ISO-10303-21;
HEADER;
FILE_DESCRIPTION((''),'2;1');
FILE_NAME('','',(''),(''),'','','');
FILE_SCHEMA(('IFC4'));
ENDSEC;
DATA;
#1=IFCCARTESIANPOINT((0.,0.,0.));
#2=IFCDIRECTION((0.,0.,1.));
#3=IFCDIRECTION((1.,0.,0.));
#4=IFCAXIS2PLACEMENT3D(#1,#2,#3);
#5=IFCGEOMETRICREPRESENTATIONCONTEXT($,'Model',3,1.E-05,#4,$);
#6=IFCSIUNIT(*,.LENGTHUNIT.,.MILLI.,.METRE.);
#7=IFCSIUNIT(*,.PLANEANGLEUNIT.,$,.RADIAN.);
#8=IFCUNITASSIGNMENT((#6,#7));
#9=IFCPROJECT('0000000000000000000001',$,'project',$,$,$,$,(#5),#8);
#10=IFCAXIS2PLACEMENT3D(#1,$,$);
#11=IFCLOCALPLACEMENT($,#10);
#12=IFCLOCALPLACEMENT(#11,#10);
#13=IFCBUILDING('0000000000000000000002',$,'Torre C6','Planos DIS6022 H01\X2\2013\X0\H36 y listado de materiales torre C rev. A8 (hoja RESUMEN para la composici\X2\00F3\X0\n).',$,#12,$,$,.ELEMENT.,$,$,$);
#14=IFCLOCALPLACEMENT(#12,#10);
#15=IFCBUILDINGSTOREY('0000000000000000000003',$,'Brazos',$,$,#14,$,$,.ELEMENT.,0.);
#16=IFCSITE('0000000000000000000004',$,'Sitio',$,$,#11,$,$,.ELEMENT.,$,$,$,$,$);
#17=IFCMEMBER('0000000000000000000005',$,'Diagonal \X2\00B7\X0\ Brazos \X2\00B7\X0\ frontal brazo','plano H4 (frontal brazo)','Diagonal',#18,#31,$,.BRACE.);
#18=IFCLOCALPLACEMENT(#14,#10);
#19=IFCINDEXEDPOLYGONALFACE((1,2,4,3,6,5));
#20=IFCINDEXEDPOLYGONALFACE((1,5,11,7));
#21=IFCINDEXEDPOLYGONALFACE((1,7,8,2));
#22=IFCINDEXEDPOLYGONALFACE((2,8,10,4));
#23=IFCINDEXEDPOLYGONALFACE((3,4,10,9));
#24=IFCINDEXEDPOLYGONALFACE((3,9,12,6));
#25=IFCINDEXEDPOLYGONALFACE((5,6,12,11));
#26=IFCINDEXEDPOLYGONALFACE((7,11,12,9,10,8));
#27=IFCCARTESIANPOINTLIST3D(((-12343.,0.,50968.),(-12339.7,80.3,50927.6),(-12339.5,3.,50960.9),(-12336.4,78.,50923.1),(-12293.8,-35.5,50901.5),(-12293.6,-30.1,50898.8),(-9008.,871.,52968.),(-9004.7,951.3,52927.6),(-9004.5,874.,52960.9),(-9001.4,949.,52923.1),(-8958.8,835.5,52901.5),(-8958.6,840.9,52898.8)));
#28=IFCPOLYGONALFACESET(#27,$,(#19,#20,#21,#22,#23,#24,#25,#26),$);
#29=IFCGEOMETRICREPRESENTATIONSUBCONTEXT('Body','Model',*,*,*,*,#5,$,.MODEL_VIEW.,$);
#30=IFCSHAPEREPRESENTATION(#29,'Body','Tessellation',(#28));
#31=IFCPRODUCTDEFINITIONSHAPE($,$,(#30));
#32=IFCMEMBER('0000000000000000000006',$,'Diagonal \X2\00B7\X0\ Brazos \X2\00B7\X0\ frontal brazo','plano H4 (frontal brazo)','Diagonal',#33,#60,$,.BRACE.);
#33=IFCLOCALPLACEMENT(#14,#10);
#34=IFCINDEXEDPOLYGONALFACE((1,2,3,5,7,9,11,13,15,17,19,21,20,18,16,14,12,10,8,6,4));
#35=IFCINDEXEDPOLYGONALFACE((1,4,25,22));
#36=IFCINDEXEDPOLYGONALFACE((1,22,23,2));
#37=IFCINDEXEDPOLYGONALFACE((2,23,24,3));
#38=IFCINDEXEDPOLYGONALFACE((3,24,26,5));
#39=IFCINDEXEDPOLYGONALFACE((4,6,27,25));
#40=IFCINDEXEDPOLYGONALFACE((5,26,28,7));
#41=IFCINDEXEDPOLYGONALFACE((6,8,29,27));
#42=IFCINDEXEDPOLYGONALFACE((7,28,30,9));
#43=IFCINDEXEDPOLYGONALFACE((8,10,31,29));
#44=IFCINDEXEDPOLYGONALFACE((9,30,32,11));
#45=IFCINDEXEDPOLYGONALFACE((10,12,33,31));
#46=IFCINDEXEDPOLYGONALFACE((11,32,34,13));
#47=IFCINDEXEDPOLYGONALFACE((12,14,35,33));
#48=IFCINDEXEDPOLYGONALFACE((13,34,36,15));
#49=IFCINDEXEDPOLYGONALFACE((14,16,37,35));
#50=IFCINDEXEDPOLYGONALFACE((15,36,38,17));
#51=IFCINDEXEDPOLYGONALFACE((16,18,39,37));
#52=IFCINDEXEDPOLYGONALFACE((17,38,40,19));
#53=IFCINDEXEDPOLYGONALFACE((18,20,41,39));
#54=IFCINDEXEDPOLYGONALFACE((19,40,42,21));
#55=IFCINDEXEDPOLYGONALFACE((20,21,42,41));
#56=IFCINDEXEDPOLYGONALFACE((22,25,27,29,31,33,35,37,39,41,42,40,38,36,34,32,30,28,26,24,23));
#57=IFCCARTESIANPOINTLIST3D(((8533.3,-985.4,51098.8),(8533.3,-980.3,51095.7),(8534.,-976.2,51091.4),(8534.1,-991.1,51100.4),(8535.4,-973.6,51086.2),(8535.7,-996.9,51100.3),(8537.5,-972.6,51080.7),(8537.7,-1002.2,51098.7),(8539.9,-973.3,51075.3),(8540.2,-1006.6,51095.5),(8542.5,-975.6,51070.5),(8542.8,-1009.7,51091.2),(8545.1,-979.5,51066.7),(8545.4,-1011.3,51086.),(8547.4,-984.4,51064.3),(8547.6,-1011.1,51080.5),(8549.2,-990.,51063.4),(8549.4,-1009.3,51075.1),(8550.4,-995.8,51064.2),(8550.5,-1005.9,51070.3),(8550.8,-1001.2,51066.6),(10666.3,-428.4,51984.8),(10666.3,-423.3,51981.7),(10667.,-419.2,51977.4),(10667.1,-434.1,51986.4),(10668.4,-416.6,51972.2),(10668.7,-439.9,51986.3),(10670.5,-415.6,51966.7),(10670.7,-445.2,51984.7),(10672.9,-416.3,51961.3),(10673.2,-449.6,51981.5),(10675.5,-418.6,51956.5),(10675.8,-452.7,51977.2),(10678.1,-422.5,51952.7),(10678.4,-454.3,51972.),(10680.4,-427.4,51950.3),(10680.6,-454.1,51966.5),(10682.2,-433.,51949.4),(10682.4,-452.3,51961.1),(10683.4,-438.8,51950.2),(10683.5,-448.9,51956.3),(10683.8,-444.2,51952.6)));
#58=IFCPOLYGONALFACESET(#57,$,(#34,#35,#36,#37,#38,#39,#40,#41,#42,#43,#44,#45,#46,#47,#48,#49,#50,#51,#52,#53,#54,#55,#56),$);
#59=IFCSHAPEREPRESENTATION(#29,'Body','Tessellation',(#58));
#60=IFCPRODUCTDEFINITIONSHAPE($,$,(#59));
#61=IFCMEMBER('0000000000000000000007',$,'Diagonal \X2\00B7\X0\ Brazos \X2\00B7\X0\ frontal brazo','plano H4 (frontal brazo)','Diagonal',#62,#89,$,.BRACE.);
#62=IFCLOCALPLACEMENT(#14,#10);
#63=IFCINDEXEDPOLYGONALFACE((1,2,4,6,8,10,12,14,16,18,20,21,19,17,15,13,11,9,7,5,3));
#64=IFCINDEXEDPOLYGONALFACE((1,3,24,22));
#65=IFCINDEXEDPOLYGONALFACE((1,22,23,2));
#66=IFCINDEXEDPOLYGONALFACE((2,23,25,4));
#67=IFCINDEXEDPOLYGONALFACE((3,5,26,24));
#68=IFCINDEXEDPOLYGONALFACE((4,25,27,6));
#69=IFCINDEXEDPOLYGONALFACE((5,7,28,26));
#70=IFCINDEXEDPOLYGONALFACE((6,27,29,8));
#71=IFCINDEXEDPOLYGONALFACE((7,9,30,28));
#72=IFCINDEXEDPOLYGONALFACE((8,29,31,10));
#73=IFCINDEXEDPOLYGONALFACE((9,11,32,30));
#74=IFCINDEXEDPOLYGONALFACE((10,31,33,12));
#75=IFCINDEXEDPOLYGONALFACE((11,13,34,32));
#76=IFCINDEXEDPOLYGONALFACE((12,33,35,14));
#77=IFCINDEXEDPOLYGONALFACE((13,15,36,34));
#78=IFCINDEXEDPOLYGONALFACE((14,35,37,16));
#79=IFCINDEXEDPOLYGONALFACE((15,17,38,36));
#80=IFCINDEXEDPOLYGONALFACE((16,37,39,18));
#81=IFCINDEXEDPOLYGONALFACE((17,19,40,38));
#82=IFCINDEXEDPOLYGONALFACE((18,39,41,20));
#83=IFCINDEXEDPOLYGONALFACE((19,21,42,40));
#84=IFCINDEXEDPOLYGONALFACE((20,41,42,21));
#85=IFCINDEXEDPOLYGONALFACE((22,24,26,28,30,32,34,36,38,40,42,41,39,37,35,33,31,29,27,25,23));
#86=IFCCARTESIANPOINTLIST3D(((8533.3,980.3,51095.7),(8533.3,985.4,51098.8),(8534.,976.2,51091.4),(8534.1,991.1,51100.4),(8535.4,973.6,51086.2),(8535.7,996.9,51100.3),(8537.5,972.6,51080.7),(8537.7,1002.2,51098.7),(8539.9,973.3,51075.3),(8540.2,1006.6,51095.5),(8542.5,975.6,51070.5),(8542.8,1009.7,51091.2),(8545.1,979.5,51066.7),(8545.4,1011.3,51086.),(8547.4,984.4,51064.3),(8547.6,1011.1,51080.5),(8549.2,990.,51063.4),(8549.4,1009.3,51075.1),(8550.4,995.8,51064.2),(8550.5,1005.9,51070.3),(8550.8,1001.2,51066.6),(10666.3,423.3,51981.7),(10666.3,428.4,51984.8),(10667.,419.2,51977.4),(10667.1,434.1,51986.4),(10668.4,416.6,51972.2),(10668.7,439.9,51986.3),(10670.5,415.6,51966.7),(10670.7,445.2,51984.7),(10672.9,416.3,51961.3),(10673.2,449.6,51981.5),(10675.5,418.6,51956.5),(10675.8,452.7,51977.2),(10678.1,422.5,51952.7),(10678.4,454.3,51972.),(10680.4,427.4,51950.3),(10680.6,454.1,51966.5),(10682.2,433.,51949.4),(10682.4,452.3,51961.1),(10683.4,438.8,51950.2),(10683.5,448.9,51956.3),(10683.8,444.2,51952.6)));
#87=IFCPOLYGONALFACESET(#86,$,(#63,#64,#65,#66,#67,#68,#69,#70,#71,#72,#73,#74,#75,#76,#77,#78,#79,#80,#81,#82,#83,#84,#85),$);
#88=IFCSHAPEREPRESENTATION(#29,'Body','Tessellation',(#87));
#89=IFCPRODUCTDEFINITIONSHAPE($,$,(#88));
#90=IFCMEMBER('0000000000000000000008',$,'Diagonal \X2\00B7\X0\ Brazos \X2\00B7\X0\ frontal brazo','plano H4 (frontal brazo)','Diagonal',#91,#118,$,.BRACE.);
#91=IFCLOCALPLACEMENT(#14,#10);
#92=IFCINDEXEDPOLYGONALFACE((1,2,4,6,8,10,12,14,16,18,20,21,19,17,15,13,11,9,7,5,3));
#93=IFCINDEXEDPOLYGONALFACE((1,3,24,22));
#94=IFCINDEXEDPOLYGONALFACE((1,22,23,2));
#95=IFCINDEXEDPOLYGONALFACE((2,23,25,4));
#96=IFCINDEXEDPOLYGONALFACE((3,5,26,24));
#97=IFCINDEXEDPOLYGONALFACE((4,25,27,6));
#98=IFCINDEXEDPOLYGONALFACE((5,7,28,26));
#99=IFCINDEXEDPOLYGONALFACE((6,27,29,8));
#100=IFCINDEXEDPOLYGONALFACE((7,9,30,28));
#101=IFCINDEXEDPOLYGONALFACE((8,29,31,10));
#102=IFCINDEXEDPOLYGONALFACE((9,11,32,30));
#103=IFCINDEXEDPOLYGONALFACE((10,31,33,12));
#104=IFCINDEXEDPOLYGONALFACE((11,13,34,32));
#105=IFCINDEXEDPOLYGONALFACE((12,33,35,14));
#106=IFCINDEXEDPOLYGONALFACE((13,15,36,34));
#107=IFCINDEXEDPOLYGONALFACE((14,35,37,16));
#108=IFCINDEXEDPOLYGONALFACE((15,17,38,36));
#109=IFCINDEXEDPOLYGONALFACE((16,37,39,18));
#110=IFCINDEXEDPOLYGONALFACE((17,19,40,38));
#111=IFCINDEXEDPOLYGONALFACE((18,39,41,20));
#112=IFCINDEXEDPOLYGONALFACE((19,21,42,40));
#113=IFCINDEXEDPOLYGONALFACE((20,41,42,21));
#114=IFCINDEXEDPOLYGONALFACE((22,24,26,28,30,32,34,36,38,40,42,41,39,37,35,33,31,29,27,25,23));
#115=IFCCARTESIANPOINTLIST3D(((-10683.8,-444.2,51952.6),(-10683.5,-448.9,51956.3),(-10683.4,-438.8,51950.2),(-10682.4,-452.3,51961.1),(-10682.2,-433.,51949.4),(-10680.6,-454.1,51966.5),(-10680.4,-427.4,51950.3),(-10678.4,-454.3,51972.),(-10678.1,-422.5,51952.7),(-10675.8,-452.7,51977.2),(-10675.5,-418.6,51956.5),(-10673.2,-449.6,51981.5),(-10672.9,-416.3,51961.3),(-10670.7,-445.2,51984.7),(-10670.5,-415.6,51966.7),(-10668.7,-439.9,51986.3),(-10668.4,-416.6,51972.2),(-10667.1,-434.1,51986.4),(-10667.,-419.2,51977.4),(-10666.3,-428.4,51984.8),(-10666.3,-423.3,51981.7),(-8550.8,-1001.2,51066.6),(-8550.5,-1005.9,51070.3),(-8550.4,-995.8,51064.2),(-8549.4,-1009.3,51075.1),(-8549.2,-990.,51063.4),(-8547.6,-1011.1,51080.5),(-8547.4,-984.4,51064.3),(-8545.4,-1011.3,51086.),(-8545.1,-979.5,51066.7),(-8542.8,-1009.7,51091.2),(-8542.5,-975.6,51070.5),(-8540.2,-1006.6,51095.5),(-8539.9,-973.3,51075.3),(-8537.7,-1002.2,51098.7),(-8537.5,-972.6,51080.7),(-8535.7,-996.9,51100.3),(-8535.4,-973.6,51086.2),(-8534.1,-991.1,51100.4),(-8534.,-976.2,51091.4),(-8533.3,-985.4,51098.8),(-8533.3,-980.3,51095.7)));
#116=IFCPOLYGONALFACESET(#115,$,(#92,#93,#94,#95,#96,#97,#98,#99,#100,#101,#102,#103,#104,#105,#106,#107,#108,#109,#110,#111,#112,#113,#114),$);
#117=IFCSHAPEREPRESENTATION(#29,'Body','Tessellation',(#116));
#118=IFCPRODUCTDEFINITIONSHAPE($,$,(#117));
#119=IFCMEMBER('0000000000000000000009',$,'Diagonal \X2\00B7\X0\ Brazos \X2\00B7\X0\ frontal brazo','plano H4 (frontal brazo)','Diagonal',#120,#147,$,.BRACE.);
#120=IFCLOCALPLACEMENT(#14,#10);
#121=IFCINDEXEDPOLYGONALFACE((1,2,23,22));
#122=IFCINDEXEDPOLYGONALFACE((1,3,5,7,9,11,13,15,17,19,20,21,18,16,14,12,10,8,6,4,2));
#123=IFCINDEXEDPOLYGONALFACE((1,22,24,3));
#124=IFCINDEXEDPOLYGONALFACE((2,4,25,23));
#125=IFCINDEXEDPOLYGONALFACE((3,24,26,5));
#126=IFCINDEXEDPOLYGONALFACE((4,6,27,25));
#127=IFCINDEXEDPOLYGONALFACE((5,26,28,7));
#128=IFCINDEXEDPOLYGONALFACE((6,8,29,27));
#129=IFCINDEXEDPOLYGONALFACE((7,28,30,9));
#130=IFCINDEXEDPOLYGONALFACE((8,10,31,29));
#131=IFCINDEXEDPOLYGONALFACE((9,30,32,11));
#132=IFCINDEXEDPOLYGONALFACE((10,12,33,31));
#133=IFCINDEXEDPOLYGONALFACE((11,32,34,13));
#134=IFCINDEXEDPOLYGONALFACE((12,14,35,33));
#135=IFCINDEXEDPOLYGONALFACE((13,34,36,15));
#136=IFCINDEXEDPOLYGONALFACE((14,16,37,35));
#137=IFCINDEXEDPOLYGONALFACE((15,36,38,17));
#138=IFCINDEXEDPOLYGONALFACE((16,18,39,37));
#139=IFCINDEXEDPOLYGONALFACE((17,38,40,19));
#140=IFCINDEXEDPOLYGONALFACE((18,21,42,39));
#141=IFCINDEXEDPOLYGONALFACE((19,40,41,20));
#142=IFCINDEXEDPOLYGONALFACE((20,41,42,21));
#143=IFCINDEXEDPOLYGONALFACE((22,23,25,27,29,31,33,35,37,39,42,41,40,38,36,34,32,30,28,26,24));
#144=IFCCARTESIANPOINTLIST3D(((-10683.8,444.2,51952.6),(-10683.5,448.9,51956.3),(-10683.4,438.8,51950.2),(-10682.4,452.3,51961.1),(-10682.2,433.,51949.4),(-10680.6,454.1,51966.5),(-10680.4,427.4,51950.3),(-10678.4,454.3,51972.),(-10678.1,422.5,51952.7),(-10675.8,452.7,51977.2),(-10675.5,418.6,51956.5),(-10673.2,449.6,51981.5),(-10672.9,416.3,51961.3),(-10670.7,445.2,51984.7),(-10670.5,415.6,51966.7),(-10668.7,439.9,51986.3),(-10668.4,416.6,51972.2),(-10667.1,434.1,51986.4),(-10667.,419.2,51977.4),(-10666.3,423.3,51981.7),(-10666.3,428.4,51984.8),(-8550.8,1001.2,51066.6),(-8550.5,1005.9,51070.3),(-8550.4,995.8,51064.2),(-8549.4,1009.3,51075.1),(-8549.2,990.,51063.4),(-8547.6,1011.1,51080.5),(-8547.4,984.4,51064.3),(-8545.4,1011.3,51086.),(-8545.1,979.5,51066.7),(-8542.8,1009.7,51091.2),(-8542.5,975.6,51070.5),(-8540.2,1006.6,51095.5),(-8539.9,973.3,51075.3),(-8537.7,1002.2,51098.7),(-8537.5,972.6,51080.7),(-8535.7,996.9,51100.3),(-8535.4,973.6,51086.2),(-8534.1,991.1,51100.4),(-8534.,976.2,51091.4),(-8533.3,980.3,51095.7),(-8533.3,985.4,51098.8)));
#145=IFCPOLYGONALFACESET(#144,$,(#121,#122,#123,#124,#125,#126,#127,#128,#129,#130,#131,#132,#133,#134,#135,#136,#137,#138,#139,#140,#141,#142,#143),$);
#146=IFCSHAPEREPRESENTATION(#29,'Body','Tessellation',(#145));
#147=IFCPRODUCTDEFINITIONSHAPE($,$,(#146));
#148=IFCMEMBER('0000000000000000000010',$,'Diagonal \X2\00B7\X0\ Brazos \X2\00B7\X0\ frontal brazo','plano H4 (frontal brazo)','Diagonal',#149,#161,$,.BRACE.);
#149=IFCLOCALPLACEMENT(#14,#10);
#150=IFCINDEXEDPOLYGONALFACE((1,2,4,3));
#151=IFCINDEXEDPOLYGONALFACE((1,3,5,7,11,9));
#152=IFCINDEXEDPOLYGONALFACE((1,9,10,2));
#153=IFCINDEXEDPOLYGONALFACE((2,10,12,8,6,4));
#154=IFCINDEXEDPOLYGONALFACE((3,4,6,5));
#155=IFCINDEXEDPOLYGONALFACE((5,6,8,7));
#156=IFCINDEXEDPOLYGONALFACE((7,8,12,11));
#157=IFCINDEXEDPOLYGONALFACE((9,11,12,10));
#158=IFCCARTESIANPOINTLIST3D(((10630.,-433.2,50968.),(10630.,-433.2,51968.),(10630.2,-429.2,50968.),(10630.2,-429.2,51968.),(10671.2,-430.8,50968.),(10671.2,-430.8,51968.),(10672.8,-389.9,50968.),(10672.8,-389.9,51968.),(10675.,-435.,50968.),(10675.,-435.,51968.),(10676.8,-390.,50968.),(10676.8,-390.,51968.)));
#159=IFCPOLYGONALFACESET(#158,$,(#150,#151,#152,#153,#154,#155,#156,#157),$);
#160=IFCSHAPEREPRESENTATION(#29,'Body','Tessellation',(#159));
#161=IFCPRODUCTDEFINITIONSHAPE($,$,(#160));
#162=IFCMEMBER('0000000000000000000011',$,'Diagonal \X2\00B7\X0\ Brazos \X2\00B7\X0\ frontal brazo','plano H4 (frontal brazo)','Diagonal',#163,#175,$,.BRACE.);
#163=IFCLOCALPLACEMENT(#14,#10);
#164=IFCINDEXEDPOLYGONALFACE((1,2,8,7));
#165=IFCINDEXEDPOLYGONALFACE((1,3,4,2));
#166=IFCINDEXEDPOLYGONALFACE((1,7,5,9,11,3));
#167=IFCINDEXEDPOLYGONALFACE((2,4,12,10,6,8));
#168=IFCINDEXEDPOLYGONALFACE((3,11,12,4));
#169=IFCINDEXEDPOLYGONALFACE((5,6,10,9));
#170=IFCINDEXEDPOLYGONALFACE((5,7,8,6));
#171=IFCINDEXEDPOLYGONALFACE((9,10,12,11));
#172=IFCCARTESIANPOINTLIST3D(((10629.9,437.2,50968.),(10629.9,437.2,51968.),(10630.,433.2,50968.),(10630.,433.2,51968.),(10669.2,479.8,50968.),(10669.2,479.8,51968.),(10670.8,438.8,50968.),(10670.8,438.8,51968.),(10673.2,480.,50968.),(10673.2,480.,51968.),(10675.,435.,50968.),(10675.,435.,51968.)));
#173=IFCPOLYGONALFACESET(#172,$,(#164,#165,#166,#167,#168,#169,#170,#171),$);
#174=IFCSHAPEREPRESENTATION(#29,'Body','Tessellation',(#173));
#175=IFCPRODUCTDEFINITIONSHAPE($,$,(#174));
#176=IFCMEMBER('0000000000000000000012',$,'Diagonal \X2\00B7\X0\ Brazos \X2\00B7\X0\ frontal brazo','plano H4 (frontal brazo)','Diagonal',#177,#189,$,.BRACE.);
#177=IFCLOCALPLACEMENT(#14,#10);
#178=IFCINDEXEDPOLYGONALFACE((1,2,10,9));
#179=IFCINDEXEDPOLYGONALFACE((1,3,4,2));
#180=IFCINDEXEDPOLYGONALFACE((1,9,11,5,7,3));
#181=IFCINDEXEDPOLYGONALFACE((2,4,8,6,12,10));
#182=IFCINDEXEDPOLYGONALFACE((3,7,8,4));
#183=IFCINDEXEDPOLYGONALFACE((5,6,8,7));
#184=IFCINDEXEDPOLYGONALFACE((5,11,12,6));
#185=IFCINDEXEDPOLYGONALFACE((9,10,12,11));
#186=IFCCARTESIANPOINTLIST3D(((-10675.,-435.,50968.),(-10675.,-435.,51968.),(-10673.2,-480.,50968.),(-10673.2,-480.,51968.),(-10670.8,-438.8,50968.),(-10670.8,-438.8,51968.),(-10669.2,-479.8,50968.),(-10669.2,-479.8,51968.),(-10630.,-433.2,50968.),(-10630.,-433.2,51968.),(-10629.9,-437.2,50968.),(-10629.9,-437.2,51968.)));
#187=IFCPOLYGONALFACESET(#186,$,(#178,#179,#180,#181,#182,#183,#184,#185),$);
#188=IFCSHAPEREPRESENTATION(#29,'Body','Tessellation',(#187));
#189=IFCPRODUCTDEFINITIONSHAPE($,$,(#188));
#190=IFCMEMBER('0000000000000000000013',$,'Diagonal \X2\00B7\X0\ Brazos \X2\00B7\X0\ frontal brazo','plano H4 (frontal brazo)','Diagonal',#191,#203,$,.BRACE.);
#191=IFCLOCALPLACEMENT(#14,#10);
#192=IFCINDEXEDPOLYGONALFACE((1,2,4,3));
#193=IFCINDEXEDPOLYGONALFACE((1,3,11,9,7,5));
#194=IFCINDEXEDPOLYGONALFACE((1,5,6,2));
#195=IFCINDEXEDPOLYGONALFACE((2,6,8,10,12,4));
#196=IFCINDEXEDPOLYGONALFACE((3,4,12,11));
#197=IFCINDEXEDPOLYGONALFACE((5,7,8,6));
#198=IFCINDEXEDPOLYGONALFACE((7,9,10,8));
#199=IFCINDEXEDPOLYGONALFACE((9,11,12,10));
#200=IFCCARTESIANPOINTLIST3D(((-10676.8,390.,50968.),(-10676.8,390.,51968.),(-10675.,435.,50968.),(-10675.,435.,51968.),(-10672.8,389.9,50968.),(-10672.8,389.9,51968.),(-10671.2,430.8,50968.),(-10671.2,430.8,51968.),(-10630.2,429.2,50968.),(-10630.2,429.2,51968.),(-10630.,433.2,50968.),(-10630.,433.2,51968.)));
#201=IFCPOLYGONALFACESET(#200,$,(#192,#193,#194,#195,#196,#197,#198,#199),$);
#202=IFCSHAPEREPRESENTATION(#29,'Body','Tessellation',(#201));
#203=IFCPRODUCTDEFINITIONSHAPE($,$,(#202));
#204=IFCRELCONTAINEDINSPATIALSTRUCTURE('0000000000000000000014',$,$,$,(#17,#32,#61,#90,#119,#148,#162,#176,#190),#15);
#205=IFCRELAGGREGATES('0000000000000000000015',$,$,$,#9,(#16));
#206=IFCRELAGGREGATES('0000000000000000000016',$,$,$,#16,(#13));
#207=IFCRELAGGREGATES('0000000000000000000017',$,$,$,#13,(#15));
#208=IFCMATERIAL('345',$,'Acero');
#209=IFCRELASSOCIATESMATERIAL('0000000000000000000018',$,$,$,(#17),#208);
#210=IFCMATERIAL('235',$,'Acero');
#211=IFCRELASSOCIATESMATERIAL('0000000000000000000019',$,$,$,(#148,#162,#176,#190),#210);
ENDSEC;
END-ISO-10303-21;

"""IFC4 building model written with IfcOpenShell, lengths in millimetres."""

from ifc_helpers import new_model, si_unit, frame, frame_2d, origin, origin_with_axes, place, context, subcontext, project, spatial, circle, l_section, extrude, material, element, save


model = new_model("IFC4")

# Units and contexts
model_context = context("Model", 3, precision=1e-05, world=origin_with_axes())
body_context = subcontext(model_context, "Body", "Model", "MODEL_VIEW")
ifc_project = project(units=[si_unit("LENGTHUNIT", "METRE", prefix="MILLI"), si_unit("PLANEANGLEUNIT", "RADIAN")], contexts=[model_context])

# Site, building, storey
site_placement = place(None, origin())
site = spatial("IfcSite", under=ifc_project, at=site_placement, Name="Sitio", CompositionType="ELEMENT")
building_placement = place(site_placement, origin())
building = spatial("IfcBuilding", under=site, at=building_placement, Name="Torre C6", Description="Planos DIS6022 H01–H36 y listado de materiales torre C rev. A8 (hoja RESUMEN para la composición).", CompositionType="ELEMENT")
storey_placement = place(building_placement, origin())
storey = spatial("IfcBuildingStorey", under=building, at=storey_placement, Name="Brazos", CompositionType="ELEMENT", Elevation=0.0)

# Members
ifc_material_1 = material(Name="345", Category="Acero")
for number, where, z_axis, x_axis, name in (
    (1, (-12343.0, 0.0, 50968.0), (0.836871, 0.218565, 0.501872), (0.546187, -0.394391, -0.73901), "Diagonal · Brazos · frontal brazo"),
):
    element("IfcMember", number, at=place(storey_placement, frame(where, z_axis=z_axis, x_axis=x_axis)), inside=storey, material=ifc_material_1, Name=name, Description="plano H4 (frontal brazo)", ObjectType="Diagonal", PredefinedType="BRACE", context=body_context, shape_type="SweptSolid", body=[
        extrude(l_section(Depth=90.0, Width=90.0, Thickness=6.0, at=frame_2d((45.0, 45.0))), None, (0.0, 0.0, 1.0), 3985.1),
    ])
for number, where, z_axis, x_axis, name in (
    (2, (8542.0, -992.0, 51082.0), (0.897762, 0.234437, 0.37291), (-0.436687, 0.58456, 0.683808), "Diagonal · Brazos · frontal brazo"),
    (3, (8542.0, 992.0, 51082.0), (0.897762, -0.234437, 0.37291), (-0.436687, -0.58456, 0.683808), "Diagonal · Brazos · frontal brazo"),
    (4, (-8542.0, -992.0, 51082.0), (-0.897762, 0.234437, 0.37291), (0.436687, 0.58456, 0.683808), "Diagonal · Brazos · frontal brazo"),
    (5, (-8542.0, 992.0, 51082.0), (-0.897762, -0.234437, 0.37291), (0.436687, -0.58456, 0.683808), "Diagonal · Brazos · frontal brazo"),
):
    element("IfcMember", number, at=place(storey_placement, frame(where, z_axis=z_axis, x_axis=x_axis)), inside=storey, Name=name, Description="plano H4 (frontal brazo)", ObjectType="Diagonal", PredefinedType="BRACE", context=body_context, shape_type="SweptSolid", body=[
        extrude(circle(Radius=20.0), None, (0.0, 0.0, 1.0), 2375.9),
    ])
ifc_material_2 = material(Name="235", Category="Acero")
for number, where, z_axis, x_axis, name in (
    (6, (10675.0, -435.0, 51968.0), (0.0, 0.0, -1.0), (-0.999171, 0.040716, 0.0), "Diagonal · Brazos · frontal brazo"),
    (7, (10675.0, 435.0, 51968.0), (0.0, 0.0, -1.0), (-0.999171, -0.040716, 0.0), "Diagonal · Brazos · frontal brazo"),
    (8, (-10675.0, -435.0, 51968.0), (0.0, 0.0, -1.0), (0.999171, 0.040716, 0.0), "Diagonal · Brazos · frontal brazo"),
    (9, (-10675.0, 435.0, 51968.0), (0.0, 0.0, -1.0), (0.999171, -0.040716, 0.0), "Diagonal · Brazos · frontal brazo"),
):
    element("IfcMember", number, at=place(storey_placement, frame(where, z_axis=z_axis, x_axis=x_axis)), inside=storey, material=ifc_material_2, Name=name, Description="plano H4 (frontal brazo)", ObjectType="Diagonal", PredefinedType="BRACE", context=body_context, shape_type="SweptSolid", body=[
        extrude(l_section(Depth=45.0, Width=45.0, Thickness=4.0, at=frame_2d((22.5, 22.5))), None, (0.0, 0.0, 1.0), 1000.0),
    ])

save(model, "model.ifc")
